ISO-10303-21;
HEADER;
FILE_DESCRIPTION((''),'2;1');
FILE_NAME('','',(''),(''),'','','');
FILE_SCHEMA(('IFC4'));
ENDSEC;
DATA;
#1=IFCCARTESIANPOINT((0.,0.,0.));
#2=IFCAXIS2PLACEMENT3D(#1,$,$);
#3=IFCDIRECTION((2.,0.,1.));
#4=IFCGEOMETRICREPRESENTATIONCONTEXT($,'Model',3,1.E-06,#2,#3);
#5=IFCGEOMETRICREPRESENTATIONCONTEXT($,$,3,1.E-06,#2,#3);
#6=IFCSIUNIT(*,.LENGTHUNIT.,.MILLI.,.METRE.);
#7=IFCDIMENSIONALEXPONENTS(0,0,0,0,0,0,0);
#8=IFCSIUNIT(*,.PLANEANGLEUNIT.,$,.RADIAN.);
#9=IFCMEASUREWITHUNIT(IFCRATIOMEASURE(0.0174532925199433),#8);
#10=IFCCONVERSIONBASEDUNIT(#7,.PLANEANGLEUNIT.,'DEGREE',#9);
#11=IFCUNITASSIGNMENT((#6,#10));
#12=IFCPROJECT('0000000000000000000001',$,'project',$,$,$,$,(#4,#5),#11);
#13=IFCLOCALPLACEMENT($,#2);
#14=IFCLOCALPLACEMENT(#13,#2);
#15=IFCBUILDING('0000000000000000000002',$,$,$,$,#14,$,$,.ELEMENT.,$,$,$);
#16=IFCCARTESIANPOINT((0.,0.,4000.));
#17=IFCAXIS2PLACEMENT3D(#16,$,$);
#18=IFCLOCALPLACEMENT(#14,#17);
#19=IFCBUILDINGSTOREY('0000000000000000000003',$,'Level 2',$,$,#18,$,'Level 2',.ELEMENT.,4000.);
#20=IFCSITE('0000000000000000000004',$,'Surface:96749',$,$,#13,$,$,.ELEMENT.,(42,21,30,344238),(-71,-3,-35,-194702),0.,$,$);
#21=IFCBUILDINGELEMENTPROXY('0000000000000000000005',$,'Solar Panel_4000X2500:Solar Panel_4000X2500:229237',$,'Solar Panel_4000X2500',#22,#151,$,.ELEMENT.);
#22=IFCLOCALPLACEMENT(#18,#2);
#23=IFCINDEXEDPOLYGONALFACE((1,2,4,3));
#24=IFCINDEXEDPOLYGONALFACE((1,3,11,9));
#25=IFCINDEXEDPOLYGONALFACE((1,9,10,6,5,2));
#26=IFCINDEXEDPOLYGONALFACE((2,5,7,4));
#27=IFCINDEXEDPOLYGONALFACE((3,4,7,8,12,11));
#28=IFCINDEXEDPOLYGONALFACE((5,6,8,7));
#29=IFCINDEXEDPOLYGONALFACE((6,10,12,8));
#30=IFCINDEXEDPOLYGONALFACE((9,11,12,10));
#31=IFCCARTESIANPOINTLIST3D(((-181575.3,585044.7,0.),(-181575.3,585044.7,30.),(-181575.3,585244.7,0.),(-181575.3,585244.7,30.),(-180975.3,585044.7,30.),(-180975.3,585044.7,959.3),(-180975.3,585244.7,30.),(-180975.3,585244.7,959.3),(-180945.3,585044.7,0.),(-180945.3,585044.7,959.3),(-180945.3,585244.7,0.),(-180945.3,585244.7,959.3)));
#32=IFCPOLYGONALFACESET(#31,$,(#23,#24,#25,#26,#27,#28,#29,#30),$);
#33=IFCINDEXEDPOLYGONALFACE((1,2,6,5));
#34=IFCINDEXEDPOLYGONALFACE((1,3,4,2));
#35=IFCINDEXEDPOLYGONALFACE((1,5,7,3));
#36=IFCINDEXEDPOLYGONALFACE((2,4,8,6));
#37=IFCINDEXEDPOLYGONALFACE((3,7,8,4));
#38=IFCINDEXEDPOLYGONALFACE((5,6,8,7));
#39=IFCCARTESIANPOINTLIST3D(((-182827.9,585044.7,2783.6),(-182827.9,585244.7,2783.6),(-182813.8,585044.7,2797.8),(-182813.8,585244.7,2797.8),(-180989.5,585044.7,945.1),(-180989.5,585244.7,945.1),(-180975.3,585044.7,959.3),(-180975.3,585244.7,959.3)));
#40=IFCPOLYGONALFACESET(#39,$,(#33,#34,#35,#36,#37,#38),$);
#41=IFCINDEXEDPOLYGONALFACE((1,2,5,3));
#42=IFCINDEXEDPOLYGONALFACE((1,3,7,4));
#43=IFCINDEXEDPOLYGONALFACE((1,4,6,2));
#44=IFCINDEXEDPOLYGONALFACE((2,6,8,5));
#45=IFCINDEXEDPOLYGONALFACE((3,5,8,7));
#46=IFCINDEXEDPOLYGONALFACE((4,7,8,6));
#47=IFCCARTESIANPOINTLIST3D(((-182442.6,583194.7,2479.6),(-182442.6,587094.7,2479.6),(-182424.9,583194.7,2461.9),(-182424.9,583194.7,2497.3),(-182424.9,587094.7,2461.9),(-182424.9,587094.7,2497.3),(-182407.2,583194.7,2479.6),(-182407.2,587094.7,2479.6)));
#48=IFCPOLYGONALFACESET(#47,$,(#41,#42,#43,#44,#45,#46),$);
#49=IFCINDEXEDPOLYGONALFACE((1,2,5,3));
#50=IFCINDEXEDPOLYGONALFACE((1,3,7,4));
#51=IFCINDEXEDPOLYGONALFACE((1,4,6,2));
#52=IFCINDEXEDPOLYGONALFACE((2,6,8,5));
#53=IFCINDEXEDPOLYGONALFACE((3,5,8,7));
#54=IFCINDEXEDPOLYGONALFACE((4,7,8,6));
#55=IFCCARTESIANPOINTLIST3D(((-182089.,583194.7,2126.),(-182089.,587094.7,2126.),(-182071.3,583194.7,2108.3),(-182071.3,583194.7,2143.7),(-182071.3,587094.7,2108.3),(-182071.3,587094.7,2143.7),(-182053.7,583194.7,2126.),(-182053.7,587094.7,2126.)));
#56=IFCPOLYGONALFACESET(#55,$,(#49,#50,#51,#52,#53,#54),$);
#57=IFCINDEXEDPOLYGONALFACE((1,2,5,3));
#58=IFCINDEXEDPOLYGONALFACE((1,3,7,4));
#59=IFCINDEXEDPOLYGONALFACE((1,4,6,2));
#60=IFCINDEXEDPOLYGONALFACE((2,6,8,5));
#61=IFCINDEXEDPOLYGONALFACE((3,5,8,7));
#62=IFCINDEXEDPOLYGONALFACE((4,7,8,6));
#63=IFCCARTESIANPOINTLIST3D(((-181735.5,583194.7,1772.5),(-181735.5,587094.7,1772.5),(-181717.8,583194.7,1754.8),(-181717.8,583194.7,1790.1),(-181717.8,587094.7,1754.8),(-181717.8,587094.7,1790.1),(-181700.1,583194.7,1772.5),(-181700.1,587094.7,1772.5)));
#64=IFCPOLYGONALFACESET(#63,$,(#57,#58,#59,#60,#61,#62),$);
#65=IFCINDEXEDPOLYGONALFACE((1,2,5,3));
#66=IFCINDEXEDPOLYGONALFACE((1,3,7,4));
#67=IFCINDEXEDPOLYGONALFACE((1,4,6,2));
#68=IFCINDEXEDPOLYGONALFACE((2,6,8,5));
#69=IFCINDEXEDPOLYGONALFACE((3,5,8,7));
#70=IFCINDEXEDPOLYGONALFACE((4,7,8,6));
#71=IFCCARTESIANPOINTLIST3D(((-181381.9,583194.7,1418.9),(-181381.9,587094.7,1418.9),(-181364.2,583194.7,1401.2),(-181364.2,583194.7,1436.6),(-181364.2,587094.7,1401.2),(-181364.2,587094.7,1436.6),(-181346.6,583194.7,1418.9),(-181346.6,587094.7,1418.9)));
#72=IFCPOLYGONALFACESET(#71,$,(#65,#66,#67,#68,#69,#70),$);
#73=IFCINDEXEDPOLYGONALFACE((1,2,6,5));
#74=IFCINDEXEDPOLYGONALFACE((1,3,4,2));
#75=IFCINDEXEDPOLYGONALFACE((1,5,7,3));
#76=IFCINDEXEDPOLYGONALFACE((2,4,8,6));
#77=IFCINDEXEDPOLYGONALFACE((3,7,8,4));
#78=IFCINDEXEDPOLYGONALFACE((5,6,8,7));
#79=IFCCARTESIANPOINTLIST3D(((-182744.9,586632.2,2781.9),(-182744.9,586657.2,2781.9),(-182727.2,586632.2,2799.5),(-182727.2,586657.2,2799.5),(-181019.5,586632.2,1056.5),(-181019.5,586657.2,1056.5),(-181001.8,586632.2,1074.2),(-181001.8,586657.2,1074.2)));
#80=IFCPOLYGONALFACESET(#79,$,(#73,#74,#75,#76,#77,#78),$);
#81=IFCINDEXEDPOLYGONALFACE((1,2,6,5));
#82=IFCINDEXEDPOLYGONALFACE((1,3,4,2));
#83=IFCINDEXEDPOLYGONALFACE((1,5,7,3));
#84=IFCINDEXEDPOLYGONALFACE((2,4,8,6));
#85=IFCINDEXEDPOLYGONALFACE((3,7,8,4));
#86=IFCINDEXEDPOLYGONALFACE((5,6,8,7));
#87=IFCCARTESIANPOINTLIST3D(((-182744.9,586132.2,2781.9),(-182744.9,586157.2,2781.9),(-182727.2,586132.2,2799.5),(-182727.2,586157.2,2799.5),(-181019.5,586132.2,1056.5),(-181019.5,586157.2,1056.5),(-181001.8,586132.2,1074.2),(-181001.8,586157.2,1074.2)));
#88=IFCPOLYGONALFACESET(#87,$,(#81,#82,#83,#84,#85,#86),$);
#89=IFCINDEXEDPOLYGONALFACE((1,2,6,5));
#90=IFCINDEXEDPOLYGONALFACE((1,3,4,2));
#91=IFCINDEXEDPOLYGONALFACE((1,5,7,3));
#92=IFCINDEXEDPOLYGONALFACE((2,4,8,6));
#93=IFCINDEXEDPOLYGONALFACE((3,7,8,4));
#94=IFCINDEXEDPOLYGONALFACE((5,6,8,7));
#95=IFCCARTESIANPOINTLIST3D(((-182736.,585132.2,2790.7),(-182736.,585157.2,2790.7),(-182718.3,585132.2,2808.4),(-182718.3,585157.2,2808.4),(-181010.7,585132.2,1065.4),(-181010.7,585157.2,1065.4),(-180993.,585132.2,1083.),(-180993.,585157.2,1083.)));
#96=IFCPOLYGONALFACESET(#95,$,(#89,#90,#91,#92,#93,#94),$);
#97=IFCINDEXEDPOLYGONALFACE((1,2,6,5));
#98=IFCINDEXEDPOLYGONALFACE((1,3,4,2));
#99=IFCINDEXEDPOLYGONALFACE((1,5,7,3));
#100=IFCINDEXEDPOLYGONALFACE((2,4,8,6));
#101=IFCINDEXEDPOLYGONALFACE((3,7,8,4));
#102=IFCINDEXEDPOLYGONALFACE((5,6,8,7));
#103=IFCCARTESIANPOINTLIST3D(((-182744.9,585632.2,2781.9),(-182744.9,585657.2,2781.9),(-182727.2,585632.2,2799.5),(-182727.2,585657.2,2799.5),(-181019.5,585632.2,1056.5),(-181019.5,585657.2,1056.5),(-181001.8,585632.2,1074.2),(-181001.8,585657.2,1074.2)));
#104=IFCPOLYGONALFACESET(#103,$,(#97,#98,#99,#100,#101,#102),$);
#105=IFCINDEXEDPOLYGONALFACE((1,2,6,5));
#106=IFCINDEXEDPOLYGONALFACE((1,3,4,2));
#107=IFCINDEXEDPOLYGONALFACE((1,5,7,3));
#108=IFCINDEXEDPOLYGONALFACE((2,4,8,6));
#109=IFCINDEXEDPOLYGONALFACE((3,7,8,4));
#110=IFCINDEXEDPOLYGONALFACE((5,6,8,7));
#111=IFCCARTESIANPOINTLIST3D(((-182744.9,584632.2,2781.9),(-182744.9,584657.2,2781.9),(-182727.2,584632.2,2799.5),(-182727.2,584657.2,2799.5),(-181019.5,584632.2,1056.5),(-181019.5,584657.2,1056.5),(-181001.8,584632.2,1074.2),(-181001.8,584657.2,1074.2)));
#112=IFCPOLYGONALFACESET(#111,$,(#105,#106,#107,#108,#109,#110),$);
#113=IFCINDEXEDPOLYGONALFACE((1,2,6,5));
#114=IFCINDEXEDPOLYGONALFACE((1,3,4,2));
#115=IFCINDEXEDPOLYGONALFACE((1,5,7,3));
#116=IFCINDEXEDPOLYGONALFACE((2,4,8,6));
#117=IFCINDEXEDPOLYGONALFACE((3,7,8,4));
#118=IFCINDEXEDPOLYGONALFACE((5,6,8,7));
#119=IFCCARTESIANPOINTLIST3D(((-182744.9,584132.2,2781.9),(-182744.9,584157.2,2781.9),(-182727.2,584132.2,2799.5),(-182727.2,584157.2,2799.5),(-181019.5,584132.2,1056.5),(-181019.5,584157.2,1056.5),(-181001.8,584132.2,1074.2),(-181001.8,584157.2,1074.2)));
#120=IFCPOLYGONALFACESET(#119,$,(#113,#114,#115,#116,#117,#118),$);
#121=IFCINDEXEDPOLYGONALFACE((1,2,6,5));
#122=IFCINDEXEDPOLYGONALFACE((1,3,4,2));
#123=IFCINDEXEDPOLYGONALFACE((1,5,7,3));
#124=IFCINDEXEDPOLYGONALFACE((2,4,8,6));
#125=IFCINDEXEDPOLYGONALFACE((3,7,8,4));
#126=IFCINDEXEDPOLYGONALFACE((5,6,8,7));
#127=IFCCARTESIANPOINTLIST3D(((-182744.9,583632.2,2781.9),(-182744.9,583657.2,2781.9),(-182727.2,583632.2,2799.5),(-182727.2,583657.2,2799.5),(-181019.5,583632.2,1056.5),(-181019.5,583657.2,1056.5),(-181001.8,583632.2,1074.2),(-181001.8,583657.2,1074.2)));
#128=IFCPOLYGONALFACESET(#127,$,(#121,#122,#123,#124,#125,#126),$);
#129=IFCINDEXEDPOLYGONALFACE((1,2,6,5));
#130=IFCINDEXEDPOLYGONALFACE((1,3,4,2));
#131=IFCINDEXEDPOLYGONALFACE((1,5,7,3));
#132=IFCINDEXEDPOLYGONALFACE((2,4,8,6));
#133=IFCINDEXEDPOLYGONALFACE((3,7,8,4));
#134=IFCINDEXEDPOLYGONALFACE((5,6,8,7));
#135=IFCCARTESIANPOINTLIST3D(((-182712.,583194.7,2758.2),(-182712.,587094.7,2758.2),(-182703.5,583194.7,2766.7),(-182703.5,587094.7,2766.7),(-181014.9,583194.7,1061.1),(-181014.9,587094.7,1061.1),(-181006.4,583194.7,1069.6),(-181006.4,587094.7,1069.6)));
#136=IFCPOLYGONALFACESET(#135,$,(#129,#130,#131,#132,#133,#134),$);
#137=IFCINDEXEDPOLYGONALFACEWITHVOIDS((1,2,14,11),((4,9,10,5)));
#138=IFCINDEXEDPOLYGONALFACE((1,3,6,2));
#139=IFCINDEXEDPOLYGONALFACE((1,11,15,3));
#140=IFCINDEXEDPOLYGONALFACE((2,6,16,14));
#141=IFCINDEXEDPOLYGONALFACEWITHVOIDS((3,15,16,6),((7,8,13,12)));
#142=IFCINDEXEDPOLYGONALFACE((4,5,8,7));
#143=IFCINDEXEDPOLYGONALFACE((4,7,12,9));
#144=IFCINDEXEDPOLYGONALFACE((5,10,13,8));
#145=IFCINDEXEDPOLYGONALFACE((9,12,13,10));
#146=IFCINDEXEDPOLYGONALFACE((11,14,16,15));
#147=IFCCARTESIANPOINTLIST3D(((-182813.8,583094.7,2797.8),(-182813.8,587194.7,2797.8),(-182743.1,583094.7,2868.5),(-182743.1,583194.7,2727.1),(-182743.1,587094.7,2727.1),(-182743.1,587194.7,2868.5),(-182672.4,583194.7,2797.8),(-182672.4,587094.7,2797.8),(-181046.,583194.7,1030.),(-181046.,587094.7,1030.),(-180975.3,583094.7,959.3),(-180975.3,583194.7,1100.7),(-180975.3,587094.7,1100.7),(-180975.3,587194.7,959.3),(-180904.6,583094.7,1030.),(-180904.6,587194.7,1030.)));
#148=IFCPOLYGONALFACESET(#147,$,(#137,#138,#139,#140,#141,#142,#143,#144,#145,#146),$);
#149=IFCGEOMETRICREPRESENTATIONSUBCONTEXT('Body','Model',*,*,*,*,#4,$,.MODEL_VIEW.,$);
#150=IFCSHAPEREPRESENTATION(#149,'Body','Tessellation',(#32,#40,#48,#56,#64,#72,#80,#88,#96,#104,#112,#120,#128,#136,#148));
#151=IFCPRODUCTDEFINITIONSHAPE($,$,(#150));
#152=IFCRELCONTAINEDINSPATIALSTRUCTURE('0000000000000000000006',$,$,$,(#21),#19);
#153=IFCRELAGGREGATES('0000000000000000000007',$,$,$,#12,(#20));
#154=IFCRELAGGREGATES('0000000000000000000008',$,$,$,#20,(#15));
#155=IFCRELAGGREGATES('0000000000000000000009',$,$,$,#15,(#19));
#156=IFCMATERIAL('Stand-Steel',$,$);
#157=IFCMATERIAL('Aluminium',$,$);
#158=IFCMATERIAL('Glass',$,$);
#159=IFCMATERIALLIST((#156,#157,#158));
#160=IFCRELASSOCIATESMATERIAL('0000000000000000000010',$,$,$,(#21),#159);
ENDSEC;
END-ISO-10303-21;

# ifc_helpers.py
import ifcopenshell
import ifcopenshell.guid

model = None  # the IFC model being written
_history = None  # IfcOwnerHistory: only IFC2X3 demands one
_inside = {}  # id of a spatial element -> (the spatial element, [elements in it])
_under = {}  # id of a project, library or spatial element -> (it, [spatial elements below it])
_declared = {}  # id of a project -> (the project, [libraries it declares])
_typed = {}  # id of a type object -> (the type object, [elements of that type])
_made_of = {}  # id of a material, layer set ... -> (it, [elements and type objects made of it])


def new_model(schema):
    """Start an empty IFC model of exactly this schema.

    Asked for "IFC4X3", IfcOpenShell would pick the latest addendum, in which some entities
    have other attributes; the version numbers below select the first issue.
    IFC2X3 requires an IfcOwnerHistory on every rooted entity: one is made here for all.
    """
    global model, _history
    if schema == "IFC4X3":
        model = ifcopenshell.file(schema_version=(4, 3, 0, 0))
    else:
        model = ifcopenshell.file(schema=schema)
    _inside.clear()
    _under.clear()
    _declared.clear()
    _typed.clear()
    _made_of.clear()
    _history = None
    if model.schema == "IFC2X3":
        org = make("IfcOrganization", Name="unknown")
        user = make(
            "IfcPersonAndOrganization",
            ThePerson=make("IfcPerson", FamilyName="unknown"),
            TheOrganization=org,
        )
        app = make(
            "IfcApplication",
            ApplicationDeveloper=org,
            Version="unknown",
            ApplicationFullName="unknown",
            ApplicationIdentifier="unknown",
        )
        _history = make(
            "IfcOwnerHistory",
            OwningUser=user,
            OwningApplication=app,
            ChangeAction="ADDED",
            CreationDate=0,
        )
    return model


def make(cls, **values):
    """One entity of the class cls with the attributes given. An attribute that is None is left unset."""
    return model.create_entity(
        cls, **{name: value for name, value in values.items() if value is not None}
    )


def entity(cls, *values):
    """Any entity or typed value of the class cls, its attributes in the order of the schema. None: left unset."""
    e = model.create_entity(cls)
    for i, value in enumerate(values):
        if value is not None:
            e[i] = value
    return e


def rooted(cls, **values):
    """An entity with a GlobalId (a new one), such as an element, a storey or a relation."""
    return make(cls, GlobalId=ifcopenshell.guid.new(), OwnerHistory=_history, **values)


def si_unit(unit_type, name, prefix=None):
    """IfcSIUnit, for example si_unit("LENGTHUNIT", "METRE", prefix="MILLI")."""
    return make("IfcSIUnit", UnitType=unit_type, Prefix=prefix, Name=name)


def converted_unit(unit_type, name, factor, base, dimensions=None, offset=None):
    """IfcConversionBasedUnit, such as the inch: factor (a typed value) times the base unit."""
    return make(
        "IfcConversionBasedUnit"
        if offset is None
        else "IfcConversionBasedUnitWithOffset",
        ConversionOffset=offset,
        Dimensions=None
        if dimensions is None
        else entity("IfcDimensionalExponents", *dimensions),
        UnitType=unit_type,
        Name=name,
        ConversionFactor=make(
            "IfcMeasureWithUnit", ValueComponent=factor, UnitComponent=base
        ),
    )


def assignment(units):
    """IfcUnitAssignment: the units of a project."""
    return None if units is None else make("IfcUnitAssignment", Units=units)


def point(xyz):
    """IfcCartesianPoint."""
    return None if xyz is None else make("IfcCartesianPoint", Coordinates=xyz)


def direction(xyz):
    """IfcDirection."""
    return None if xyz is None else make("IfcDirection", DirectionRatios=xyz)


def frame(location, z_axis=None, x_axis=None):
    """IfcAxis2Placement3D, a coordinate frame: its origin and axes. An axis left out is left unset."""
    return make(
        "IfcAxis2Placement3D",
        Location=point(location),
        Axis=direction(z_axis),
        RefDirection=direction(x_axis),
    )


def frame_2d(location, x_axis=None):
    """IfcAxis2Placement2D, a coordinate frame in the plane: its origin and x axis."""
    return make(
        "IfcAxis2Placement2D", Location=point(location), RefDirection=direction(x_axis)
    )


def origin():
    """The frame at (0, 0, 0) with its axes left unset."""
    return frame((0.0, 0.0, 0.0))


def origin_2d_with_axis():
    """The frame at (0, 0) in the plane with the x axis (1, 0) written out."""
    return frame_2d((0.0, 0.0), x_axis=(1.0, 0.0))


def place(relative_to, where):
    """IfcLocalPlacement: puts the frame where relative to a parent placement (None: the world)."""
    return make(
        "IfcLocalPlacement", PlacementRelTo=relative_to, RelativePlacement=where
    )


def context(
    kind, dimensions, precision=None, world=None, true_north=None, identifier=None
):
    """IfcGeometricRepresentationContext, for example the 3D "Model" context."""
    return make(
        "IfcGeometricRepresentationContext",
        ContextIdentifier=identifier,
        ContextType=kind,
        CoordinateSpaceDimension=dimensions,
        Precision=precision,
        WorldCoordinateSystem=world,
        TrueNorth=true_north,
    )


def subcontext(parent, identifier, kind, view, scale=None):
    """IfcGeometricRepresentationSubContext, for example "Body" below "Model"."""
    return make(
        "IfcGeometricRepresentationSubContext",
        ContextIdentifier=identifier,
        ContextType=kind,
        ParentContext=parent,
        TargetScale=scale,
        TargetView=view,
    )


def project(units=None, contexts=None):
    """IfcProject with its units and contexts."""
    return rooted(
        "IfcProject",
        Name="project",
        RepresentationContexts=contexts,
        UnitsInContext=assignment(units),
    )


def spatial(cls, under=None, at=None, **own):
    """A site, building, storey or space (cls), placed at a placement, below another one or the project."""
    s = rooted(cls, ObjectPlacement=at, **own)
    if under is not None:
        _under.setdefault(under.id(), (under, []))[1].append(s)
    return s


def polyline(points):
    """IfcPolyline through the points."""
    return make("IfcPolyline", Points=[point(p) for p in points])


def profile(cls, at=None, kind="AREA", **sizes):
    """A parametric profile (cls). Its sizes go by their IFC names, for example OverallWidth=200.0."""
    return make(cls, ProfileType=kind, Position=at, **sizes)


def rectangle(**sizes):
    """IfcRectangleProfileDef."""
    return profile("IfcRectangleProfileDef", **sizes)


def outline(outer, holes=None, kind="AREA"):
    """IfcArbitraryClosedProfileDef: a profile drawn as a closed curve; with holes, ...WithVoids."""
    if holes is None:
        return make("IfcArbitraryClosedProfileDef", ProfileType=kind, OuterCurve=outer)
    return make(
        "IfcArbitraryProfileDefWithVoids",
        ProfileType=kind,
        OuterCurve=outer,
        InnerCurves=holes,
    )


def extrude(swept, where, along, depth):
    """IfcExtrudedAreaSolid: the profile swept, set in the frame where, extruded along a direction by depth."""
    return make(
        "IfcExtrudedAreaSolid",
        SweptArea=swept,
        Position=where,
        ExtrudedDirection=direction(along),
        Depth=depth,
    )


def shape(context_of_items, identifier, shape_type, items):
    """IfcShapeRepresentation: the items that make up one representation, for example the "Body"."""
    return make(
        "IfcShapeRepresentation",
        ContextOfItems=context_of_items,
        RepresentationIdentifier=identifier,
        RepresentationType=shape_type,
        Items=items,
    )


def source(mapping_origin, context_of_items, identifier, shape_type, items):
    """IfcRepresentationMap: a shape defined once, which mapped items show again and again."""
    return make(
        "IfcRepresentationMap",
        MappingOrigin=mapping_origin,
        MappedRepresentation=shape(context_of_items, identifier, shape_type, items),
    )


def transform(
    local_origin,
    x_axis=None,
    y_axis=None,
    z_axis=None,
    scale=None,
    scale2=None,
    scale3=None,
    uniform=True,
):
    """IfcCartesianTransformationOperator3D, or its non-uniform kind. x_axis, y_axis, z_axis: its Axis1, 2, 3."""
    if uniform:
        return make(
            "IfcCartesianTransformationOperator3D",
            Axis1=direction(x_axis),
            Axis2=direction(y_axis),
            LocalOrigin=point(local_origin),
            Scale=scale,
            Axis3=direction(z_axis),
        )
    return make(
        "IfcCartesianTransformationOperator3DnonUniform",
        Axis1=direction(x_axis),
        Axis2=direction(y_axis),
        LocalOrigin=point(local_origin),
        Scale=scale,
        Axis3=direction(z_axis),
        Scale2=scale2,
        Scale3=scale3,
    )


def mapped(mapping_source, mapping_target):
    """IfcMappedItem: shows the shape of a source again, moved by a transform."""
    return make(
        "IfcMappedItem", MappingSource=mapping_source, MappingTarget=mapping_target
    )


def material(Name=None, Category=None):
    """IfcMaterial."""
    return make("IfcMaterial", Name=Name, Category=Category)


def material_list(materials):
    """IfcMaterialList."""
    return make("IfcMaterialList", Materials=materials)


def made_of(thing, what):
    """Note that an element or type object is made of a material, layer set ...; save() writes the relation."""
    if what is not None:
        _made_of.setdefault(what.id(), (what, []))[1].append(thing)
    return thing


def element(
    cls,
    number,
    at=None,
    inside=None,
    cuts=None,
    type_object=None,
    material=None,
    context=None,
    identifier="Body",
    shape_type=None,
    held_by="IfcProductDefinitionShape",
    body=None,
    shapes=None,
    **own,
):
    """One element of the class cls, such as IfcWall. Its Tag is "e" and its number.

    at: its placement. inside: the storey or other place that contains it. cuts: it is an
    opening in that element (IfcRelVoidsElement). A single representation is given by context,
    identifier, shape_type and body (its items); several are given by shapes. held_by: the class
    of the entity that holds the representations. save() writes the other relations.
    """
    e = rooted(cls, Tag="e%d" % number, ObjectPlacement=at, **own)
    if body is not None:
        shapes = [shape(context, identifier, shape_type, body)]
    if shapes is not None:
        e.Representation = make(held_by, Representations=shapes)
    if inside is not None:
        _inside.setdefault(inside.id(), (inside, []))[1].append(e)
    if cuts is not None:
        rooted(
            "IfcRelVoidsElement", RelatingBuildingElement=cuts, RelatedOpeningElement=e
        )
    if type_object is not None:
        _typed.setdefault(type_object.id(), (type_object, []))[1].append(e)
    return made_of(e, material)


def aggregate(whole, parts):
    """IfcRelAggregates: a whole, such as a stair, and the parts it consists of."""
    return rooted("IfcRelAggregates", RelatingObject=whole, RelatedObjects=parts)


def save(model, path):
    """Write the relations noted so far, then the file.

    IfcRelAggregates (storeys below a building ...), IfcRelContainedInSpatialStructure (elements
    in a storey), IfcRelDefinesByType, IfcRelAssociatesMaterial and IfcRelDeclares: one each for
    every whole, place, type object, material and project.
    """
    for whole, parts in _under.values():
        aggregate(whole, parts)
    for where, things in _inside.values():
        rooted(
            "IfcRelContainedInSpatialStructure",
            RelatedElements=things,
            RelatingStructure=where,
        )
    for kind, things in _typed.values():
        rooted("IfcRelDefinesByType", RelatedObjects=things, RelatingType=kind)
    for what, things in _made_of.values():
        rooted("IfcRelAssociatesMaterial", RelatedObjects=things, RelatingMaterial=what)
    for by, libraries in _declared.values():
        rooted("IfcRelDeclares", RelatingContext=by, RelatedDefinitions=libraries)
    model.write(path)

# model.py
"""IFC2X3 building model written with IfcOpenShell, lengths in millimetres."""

from ifc_helpers import new_model, entity, si_unit, converted_unit, direction, frame, frame_2d, origin, origin_2d_with_axis, place, context, subcontext, project, spatial, polyline, rectangle, outline, extrude, source, transform, mapped, material, material_list, element, save


model = new_model("IFC2X3")

# Units and contexts
model_context = context("Model", 3, precision=1e-06, world=origin(), true_north=direction((2.0, 0.0, 1.0)))
context_of_model = context(None, 3, precision=1e-06, world=origin(), true_north=direction((2.0, 0.0, 1.0)))
body_context = subcontext(model_context, "Body", "Model", "MODEL_VIEW")
ifc_project = project(units=[si_unit("LENGTHUNIT", "METRE", prefix="MILLI"), converted_unit("PLANEANGLEUNIT", "DEGREE", entity("IfcRatioMeasure", 0.0174532925199433), si_unit("PLANEANGLEUNIT", "RADIAN"), dimensions=[0, 0, 0, 0, 0, 0, 0])], contexts=[model_context, context_of_model])

# Site, building, storey
site_placement = place(None, origin())
site = spatial("IfcSite", under=ifc_project, at=site_placement, Name="Surface:96749", CompositionType="ELEMENT", RefLatitude=(42, 21, 30, 344238), RefLongitude=(-71, -3, -35, -194702), RefElevation=0.0)
building_placement = place(site_placement, origin())
building = spatial("IfcBuilding", under=site, at=building_placement, CompositionType="ELEMENT")
storey_placement = place(building_placement, frame((0.0, 0.0, 4000.0)))
storey = spatial("IfcBuildingStorey", under=building, at=storey_placement, Name="Level 2", LongName="Level 2", CompositionType="ELEMENT", Elevation=4000.0)

# Building element proxy
ifc_material_1 = material(Name="Stand-Steel")
ifc_material_2 = material(Name="Aluminium")
ifc_material_3 = material(Name="Glass")
shared_shape = source(origin(), body_context, "Body", "SweptSolid", [
    extrude(outline(polyline([(-629.5, -220.0), (329.8, -220.0), (329.8, 410.0), (299.8, 410.0), (299.8, -190.0), (-629.5, -190.0), (-629.5, -220.0)])), frame((-190.0, -100.0, 299.8), z_axis=(0.0, 1.0, 0.0), x_axis=(0.0, 0.0, -1.0)), (0.0, 0.0, 1.0), 200.0),
    extrude(rectangle(XDim=20.0, YDim=200.0, at=frame_2d((0.0, 0.0), x_axis=(0.0, 1.0))), frame((-7.1, 0.0, 922.2), z_axis=(-0.707107, 0.0, 0.707107), x_axis=(0.0, 1.0, 0.0)), (0.0, 0.0, 1.0), 2600.0),
    extrude(rectangle(XDim=25.0, YDim=25.0, at=frame_2d((0.0, 0.0), x_axis=(1.0, 0.0))), frame((-1449.6, -1950.0, 2449.6), z_axis=(0.0, 1.0, 0.0), x_axis=(-0.707107, 0.0, -0.707107)), (0.0, 0.0, 1.0), 3900.0),
    extrude(rectangle(XDim=25.0, YDim=25.0, at=origin_2d_with_axis()), frame((-1096.0, -1950.0, 2096.0), z_axis=(0.0, 1.0, 0.0), x_axis=(-0.707107, 0.0, -0.707107)), (0.0, 0.0, 1.0), 3900.0),
    extrude(rectangle(XDim=25.0, YDim=25.0, at=origin_2d_with_axis()), frame((-742.5, -1950.0, 1742.5), z_axis=(0.0, 1.0, 0.0), x_axis=(-0.707107, 0.0, -0.707107)), (0.0, 0.0, 1.0), 3900.0),
    extrude(rectangle(XDim=25.0, YDim=25.0, at=frame_2d((0.0, 0.0), x_axis=(1.0, 0.0))), frame((-388.9, -1950.0, 1388.9), z_axis=(0.0, 1.0, 0.0), x_axis=(-0.707107, 0.0, -0.707107)), (0.0, 0.0, 1.0), 3900.0),
    extrude(rectangle(XDim=25.0, YDim=25.0, at=frame_2d((0.0, 0.0), x_axis=(0.0, 1.0))), frame((-35.4, 1500.0, 1035.4), z_axis=(-0.707107, 0.0, 0.707107), x_axis=(0.0, 1.0, 0.0)), (0.0, 0.0, 1.0), 2440.0),
    extrude(rectangle(XDim=25.0, YDim=25.0, at=frame_2d((0.0, 0.0), x_axis=(0.0, 1.0))), frame((-35.4, 1000.0, 1035.4), z_axis=(-0.707107, 0.0, 0.707107), x_axis=(0.0, 1.0, 0.0)), (0.0, 0.0, 1.0), 2440.0),
    extrude(rectangle(XDim=25.0, YDim=25.0, at=frame_2d((0.0, 0.0), x_axis=(0.0, 1.0))), frame((-26.5, 0.0, 1044.2), z_axis=(-0.707107, 0.0, 0.707107), x_axis=(0.0, -1.0, 0.0)), (0.0, 0.0, 1.0), 2440.0),
    extrude(rectangle(XDim=25.0, YDim=25.0, at=frame_2d((0.0, 0.0), x_axis=(0.0, 1.0))), frame((-35.4, 500.0, 1035.4), z_axis=(-0.707107, 0.0, 0.707107), x_axis=(0.0, 1.0, 0.0)), (0.0, 0.0, 1.0), 2440.0),
    extrude(rectangle(XDim=25.0, YDim=25.0, at=frame_2d((0.0, 0.0), x_axis=(0.0, 1.0))), frame((-35.4, -500.0, 1035.4), z_axis=(-0.707107, 0.0, 0.707107), x_axis=(0.0, 1.0, 0.0)), (0.0, 0.0, 1.0), 2440.0),
    extrude(rectangle(XDim=25.0, YDim=25.0, at=frame_2d((0.0, 0.0), x_axis=(0.0, 1.0))), frame((-35.4, -1000.0, 1035.4), z_axis=(-0.707107, 0.0, 0.707107), x_axis=(0.0, 1.0, 0.0)), (0.0, 0.0, 1.0), 2440.0),
    extrude(rectangle(XDim=25.0, YDim=25.0, at=frame_2d((0.0, 0.0), x_axis=(0.0, 1.0))), frame((-35.4, -1500.0, 1035.4), z_axis=(-0.707107, 0.0, 0.707107), x_axis=(0.0, 1.0, 0.0)), (0.0, 0.0, 1.0), 2440.0),
    extrude(rectangle(XDim=2400.0, YDim=12.0, at=frame_2d((0.0, 0.0), x_axis=(1.0, 0.0))), frame((-883.9, -1950.0, 1883.9), z_axis=(0.0, 1.0, 0.0), x_axis=(0.707107, 0.0, -0.707107)), (0.0, 0.0, 1.0), 3900.0),
    extrude(outline(polyline([(-2050.0, -1300.0), (2050.0, -1300.0), (2050.0, 1300.0), (-2050.0, 1300.0), (-2050.0, -1300.0)]), holes=[polyline([(1950.0, -1200.0), (-1950.0, -1200.0), (-1950.0, 1200.0), (1950.0, 1200.0), (1950.0, -1200.0)])]), frame((-919.2, 0.0, 1848.5), z_axis=(0.707107, 0.0, 0.707107), x_axis=(0.0, 1.0, 0.0)), (0.0, 0.0, 1.0), 100.0),
])
ifc_material_list_1 = material_list([ifc_material_1, ifc_material_2, ifc_material_3])
proxy_1_placement = place(storey_placement, frame((-180975.3, 585144.7, 30.0)))
element("IfcBuildingElementProxy", 1, at=proxy_1_placement, inside=storey, material=ifc_material_list_1, Name="Solar Panel_4000X2500:Solar Panel_4000X2500:229237", ObjectType="Solar Panel_4000X2500", CompositionType="ELEMENT", context=body_context, shape_type="MappedRepresentation", body=[
    mapped(shared_shape, transform((0.0, 0.0, 0.0), scale=1.0)),
])

save(model, "model.ifc")
